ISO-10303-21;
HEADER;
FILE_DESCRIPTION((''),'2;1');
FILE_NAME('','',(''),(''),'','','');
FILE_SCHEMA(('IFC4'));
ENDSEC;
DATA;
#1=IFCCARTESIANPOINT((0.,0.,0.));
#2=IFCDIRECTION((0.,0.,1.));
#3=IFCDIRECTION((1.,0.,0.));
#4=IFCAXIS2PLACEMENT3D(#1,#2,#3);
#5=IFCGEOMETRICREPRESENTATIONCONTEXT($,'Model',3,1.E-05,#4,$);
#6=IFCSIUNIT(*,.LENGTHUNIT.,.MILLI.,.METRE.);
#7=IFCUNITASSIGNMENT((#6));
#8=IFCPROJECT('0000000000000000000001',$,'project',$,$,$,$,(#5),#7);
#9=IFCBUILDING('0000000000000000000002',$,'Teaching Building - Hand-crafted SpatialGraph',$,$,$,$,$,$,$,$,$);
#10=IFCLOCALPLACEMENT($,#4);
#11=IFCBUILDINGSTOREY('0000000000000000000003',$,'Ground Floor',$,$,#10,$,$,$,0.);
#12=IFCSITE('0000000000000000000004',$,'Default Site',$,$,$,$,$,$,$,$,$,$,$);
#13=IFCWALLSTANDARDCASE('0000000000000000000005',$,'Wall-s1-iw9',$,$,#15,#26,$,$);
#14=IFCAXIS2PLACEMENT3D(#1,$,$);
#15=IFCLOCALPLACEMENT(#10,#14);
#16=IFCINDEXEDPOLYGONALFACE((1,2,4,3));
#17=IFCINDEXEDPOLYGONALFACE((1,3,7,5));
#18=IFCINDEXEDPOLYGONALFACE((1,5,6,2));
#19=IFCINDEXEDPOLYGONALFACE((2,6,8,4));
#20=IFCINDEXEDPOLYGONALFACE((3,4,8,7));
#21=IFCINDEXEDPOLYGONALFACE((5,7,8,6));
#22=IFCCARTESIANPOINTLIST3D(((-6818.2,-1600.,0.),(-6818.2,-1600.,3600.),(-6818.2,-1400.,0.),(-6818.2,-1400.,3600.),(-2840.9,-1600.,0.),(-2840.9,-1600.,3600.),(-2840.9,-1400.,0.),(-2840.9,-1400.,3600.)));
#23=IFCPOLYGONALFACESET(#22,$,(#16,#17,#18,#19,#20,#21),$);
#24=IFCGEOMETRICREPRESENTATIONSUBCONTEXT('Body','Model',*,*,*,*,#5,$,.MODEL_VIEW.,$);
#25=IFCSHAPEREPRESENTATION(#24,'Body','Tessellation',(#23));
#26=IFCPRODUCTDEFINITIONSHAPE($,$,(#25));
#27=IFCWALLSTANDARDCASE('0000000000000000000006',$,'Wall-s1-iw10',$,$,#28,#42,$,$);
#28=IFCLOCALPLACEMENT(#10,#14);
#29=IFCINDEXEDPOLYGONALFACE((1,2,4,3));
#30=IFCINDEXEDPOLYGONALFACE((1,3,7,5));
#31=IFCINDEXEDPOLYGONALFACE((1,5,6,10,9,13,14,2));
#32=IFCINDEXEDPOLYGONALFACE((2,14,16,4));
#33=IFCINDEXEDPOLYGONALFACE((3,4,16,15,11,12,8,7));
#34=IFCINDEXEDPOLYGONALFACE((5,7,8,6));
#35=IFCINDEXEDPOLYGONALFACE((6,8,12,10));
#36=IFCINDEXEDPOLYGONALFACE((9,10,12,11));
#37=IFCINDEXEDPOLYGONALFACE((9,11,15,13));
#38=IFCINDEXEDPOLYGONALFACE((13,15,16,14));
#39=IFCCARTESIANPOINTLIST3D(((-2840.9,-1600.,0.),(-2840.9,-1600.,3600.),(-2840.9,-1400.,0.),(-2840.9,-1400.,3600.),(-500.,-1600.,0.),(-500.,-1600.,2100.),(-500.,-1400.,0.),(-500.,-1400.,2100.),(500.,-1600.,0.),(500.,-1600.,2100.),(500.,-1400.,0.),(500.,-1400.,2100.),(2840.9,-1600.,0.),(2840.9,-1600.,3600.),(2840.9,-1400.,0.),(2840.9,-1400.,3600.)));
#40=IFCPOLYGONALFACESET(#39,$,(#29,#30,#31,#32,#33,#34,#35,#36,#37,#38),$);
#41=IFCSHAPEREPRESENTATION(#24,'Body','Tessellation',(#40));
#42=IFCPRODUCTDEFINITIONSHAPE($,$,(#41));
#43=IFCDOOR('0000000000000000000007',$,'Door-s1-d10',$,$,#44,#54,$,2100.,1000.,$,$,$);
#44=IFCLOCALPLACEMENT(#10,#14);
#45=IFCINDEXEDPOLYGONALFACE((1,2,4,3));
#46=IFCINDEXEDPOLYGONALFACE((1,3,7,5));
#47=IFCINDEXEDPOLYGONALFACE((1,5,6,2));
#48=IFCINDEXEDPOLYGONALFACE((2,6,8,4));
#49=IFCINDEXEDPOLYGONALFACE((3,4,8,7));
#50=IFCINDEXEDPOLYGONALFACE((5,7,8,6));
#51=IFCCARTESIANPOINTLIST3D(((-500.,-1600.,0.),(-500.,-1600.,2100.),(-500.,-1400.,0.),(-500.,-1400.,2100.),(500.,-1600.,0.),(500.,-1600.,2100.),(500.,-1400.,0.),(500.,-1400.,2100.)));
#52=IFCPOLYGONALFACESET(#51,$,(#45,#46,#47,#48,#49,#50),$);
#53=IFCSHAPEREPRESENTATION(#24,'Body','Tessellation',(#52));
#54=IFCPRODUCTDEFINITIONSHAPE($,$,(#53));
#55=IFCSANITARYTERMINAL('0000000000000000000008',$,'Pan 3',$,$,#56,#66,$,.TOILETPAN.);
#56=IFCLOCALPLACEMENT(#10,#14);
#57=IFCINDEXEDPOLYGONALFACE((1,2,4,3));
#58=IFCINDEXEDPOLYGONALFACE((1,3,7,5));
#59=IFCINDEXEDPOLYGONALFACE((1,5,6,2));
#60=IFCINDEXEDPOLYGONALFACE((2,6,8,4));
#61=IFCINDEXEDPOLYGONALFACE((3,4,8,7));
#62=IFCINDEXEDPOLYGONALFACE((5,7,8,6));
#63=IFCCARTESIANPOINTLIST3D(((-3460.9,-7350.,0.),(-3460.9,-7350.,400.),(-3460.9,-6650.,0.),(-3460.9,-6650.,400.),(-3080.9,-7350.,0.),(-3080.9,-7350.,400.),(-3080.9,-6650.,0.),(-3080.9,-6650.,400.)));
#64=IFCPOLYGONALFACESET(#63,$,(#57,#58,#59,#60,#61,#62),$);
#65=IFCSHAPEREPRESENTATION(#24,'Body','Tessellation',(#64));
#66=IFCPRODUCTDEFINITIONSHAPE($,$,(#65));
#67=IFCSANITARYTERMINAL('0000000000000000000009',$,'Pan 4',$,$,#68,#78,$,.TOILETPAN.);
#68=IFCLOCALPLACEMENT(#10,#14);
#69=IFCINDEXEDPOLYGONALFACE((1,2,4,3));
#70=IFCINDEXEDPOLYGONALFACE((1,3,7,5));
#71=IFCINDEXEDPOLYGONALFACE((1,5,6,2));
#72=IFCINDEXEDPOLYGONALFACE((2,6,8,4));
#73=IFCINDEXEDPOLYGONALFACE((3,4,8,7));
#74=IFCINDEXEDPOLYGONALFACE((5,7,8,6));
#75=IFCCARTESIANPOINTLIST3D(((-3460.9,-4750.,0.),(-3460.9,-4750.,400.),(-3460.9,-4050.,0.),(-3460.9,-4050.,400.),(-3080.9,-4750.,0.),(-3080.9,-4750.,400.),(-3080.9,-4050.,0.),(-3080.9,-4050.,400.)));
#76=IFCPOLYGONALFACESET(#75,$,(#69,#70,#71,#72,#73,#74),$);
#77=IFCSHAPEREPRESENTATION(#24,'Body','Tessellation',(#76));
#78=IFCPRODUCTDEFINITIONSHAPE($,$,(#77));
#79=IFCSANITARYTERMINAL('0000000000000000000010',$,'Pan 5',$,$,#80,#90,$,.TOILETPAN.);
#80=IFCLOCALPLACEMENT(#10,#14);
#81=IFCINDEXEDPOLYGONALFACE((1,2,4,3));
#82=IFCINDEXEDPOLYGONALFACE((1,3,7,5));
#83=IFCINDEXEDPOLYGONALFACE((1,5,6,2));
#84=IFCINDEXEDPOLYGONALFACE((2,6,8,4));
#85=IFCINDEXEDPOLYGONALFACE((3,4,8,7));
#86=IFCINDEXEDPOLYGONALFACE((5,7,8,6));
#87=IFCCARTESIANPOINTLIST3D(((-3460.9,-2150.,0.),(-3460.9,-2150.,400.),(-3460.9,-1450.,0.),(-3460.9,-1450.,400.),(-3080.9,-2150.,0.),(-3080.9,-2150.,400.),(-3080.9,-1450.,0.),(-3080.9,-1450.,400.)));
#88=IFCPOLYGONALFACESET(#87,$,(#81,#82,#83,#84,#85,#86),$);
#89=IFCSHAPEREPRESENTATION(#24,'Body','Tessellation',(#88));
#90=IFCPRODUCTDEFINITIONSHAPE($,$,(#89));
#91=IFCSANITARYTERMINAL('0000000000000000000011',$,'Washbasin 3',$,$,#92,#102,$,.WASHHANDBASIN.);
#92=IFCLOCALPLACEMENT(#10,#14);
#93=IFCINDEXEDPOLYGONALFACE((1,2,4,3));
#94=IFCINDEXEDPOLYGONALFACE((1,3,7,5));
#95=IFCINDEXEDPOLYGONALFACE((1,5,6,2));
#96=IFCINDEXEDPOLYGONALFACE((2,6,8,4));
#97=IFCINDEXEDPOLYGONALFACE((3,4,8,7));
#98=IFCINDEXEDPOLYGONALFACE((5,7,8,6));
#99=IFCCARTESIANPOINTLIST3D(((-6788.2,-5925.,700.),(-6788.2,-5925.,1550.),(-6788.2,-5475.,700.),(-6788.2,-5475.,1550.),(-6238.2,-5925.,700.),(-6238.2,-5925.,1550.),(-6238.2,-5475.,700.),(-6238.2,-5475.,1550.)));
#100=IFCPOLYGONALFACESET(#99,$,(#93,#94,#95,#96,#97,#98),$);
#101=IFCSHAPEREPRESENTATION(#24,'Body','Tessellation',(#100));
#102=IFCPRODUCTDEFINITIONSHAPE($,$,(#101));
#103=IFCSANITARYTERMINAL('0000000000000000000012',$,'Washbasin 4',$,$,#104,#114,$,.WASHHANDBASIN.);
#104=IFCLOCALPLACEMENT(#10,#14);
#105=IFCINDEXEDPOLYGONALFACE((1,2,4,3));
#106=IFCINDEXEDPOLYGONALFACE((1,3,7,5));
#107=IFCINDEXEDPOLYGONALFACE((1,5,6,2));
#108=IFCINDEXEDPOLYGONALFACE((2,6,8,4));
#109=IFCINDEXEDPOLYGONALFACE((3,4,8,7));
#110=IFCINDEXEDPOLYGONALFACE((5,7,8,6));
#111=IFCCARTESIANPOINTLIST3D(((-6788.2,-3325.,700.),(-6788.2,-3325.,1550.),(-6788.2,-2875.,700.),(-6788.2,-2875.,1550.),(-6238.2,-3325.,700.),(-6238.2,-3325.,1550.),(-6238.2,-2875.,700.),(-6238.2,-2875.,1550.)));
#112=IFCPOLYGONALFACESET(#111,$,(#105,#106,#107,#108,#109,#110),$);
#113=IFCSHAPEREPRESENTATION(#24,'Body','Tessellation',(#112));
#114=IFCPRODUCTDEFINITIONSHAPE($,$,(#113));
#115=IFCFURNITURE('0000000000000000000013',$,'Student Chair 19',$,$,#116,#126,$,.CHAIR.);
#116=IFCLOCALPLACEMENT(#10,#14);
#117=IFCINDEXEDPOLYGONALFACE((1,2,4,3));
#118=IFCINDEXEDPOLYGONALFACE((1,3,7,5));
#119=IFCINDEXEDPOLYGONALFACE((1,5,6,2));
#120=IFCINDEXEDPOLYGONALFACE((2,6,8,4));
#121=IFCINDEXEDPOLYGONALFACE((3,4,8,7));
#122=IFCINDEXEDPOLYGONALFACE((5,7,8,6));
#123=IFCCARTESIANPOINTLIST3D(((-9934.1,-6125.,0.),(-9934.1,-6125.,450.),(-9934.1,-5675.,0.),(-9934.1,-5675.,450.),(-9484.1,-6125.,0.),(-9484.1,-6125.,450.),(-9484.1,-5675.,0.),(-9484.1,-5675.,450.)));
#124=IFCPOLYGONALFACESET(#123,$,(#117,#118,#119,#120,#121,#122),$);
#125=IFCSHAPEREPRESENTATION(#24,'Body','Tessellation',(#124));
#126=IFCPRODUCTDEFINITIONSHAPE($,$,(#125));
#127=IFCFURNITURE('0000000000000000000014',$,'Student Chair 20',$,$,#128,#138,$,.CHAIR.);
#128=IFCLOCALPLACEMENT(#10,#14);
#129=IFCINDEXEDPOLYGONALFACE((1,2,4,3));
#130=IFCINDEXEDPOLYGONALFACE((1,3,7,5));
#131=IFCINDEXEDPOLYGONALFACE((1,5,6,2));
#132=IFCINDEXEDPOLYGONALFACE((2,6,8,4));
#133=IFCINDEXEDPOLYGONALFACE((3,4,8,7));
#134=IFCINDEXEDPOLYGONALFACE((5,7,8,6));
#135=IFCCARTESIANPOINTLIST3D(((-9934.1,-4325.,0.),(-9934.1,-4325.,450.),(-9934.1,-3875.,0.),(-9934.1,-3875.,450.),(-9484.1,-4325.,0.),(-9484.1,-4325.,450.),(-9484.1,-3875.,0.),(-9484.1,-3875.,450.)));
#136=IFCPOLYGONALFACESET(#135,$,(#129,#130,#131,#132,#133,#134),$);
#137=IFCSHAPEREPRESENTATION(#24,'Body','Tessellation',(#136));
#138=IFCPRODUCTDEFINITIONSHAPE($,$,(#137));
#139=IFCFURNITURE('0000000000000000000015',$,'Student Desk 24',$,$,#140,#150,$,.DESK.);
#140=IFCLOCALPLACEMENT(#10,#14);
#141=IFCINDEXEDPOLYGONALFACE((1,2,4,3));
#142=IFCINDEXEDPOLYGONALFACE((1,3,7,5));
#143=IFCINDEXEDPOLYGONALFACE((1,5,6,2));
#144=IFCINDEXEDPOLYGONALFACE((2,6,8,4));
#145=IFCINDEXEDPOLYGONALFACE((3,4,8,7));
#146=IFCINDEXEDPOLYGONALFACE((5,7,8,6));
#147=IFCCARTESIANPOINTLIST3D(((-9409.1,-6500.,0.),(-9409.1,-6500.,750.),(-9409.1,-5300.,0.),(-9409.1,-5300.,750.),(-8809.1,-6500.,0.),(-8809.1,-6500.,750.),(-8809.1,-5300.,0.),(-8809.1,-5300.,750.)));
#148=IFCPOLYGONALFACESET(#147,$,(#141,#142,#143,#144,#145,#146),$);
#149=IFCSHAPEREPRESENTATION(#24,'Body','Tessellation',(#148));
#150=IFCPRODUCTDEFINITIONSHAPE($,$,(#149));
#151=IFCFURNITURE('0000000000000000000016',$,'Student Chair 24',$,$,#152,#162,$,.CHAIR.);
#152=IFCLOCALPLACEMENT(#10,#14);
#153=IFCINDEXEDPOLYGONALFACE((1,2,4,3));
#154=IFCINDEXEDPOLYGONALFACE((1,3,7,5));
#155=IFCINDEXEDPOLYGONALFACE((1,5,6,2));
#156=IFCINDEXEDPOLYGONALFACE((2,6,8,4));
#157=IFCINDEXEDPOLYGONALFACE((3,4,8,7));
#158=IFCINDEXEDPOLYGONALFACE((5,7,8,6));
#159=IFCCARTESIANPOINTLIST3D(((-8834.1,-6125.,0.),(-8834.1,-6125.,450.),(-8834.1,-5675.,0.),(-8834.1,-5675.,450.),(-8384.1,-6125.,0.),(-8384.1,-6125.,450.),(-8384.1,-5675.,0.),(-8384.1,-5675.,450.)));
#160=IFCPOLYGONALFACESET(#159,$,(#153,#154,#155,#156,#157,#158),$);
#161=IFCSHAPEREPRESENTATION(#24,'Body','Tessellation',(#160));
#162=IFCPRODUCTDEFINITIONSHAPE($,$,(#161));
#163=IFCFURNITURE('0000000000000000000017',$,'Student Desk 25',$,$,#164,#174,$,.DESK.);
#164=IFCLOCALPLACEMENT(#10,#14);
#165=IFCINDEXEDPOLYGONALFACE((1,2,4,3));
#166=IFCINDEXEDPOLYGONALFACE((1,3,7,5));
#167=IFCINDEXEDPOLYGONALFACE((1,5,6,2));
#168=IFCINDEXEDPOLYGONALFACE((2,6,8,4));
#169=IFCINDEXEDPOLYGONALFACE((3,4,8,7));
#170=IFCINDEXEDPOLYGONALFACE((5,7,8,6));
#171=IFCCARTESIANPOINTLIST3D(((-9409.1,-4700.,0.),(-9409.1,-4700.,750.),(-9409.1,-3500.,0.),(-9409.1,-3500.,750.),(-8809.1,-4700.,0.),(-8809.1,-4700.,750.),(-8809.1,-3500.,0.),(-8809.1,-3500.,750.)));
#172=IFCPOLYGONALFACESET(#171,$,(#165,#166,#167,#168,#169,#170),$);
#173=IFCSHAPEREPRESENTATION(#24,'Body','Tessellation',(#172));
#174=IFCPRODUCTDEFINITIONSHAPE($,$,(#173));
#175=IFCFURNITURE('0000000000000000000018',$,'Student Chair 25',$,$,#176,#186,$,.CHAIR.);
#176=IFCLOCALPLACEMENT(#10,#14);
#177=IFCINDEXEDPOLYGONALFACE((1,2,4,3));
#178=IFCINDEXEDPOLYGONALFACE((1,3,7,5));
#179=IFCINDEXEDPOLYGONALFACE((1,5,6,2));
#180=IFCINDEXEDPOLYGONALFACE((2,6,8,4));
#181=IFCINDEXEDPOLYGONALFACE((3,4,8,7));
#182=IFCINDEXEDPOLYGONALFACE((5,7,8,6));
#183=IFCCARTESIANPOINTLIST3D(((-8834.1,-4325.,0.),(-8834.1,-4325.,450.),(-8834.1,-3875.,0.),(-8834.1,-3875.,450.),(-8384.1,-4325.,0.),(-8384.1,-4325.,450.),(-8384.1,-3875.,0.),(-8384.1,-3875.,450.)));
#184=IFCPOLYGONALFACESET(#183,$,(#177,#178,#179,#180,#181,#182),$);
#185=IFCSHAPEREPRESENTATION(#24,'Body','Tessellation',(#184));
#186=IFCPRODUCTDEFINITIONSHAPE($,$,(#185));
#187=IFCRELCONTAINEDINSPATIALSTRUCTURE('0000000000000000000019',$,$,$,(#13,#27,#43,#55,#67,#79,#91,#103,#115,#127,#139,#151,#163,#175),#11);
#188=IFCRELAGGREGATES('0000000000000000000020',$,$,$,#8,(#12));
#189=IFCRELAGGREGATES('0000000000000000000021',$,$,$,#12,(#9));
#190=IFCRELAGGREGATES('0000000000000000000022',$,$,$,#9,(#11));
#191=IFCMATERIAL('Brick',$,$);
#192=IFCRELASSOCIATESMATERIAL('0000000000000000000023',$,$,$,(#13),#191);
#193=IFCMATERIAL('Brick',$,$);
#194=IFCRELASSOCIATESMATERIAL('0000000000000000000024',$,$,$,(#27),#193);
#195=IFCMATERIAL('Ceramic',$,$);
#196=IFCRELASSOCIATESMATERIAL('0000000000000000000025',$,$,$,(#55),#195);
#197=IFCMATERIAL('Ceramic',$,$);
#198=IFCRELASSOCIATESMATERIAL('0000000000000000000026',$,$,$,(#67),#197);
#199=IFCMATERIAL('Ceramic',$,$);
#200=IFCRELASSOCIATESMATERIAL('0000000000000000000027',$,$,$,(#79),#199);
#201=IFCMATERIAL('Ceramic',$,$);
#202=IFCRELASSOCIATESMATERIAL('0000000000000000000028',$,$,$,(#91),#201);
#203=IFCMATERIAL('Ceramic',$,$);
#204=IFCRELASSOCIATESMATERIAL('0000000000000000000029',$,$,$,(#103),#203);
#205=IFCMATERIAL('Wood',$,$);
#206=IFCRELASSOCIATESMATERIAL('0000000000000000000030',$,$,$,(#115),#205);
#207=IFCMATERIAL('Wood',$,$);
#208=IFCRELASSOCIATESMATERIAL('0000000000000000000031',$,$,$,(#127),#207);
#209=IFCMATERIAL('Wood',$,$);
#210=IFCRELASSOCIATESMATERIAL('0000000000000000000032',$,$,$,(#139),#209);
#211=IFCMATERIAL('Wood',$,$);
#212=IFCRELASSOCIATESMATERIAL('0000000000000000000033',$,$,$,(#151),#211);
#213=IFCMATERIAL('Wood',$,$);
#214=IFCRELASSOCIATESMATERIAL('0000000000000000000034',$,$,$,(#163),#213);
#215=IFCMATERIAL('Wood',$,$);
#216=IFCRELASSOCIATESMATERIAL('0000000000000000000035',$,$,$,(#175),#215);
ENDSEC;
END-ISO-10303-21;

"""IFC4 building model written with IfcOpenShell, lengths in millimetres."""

from ifc_helpers import new_model, si_unit, frame, frame_2d, origin_with_axes, origin_2d, place, context, subcontext, project, spatial, rectangle, extrude, material, element, fill, save


model = new_model("IFC4")

# Units and contexts
model_context = context("Model", 3, precision=1e-05, world=origin_with_axes())
body_context = subcontext(model_context, "Body", "Model", "MODEL_VIEW")
ifc_project = project(units=[si_unit("LENGTHUNIT", "METRE", prefix="MILLI")], contexts=[model_context])

# Site, building, storey
site = spatial("IfcSite", under=ifc_project, Name="Default Site")
building = spatial("IfcBuilding", under=site, Name="Teaching Building - Hand-crafted SpatialGraph")
storey_placement = place(None, origin_with_axes())
storey = spatial("IfcBuildingStorey", under=building, at=storey_placement, Name="Ground Floor", Elevation=0.0)

# Wall
ifc_material_1 = material(Name="Brick")
wall_1_placement = place(storey_placement, frame((-6818.2, -1500.0, 0.0), z_axis=(0.0, 0.0, 1.0), x_axis=(1.0, 0.0, 0.0)))
element("IfcWallStandardCase", 1, at=wall_1_placement, inside=storey, material=ifc_material_1, Name="Wall-s1-iw9", context=body_context, shape_type="SweptSolid", body=[
    extrude(rectangle(XDim=3977.3, YDim=200.0, at=frame_2d((1988.6, 0.0))), origin_with_axes(), (0.0, 0.0, 1.0), 3600.0),
])

# Wall, opening, door
ifc_material_2 = material(Name="Brick")
wall_2_placement = place(storey_placement, frame((-2840.9, -1500.0, 0.0), z_axis=(0.0, 0.0, 1.0), x_axis=(1.0, 0.0, 0.0)))
wall_2 = element("IfcWallStandardCase", 2, at=wall_2_placement, inside=storey, material=ifc_material_2, Name="Wall-s1-iw10", context=body_context, shape_type="SweptSolid", body=[
    extrude(rectangle(XDim=5681.8, YDim=200.0, at=frame_2d((2840.9, 0.0))), origin_with_axes(), (0.0, 0.0, 1.0), 3600.0),
])
opening_placement = place(wall_2_placement, frame((2340.9, 0.0, 0.0), z_axis=(0.0, 0.0, 1.0), x_axis=(1.0, 0.0, 0.0)))
opening = element("IfcOpeningElement", 3, at=opening_placement, cuts=wall_2, context=body_context, shape_type="SweptSolid", body=[
    extrude(rectangle(XDim=1000.0, YDim=400.0, at=frame_2d((500.0, 0.0))), origin_with_axes(), (0.0, 0.0, 1.0), 2100.0),
])
door_placement = place(storey_placement, frame((-500.0, -1500.0, 0.0), z_axis=(0.0, 0.0, 1.0), x_axis=(1.0, 0.0, 0.0)))
door = element("IfcDoor", 4, at=door_placement, inside=storey, Name="Door-s1-d10", OverallHeight=2100.0, OverallWidth=1000.0, context=body_context, shape_type="SweptSolid", body=[
    extrude(rectangle(XDim=1000.0, YDim=200.0, at=frame_2d((500.0, 0.0))), origin_with_axes(), (0.0, 0.0, 1.0), 2100.0),
])
fill(opening, door)

# Sanitary terminals
ifc_material_3 = material(Name="Ceramic")
sanitary_terminal_1_placement = place(storey_placement, frame((-3270.9, -7000.0, 0.0), z_axis=(0.0, 0.0, 1.0), x_axis=(0.0, 1.0, 0.0)))
element("IfcSanitaryTerminal", 5, at=sanitary_terminal_1_placement, inside=storey, material=ifc_material_3, Name="Pan 3", PredefinedType="TOILETPAN", context=body_context, shape_type="SweptSolid", body=[
    extrude(rectangle(XDim=700.0, YDim=380.0, at=origin_2d()), origin_with_axes(), (0.0, 0.0, 1.0), 400.0),
])
ifc_material_4 = material(Name="Ceramic")
sanitary_terminal_2_placement = place(storey_placement, frame((-3270.9, -4400.0, 0.0), z_axis=(0.0, 0.0, 1.0), x_axis=(0.0, 1.0, 0.0)))
element("IfcSanitaryTerminal", 6, at=sanitary_terminal_2_placement, inside=storey, material=ifc_material_4, Name="Pan 4", PredefinedType="TOILETPAN", context=body_context, shape_type="SweptSolid", body=[
    extrude(rectangle(XDim=700.0, YDim=380.0, at=origin_2d()), origin_with_axes(), (0.0, 0.0, 1.0), 400.0),
])
ifc_material_5 = material(Name="Ceramic")
sanitary_terminal_3_placement = place(storey_placement, frame((-3270.9, -1800.0, 0.0), z_axis=(0.0, 0.0, 1.0), x_axis=(0.0, 1.0, 0.0)))
element("IfcSanitaryTerminal", 7, at=sanitary_terminal_3_placement, inside=storey, material=ifc_material_5, Name="Pan 5", PredefinedType="TOILETPAN", context=body_context, shape_type="SweptSolid", body=[
    extrude(rectangle(XDim=700.0, YDim=380.0, at=origin_2d()), origin_with_axes(), (0.0, 0.0, 1.0), 400.0),
])
ifc_material_6 = material(Name="Ceramic")
sanitary_terminal_4_placement = place(storey_placement, frame((-6513.2, -5700.0, 700.0), z_axis=(0.0, 0.0, 1.0), x_axis=(0.0, 1.0, 0.0)))
element("IfcSanitaryTerminal", 8, at=sanitary_terminal_4_placement, inside=storey, material=ifc_material_6, Name="Washbasin 3", PredefinedType="WASHHANDBASIN", context=body_context, shape_type="SweptSolid", body=[
    extrude(rectangle(XDim=450.0, YDim=550.0, at=origin_2d()), origin_with_axes(), (0.0, 0.0, 1.0), 850.0),
])
ifc_material_7 = material(Name="Ceramic")
sanitary_terminal_5_placement = place(storey_placement, frame((-6513.2, -3100.0, 700.0), z_axis=(0.0, 0.0, 1.0), x_axis=(0.0, 1.0, 0.0)))
element("IfcSanitaryTerminal", 9, at=sanitary_terminal_5_placement, inside=storey, material=ifc_material_7, Name="Washbasin 4", PredefinedType="WASHHANDBASIN", context=body_context, shape_type="SweptSolid", body=[
    extrude(rectangle(XDim=450.0, YDim=550.0, at=origin_2d()), origin_with_axes(), (0.0, 0.0, 1.0), 850.0),
])

# Furniture
ifc_material_8 = material(Name="Wood")
furniture_1_placement = place(storey_placement, frame((-9709.1, -5900.0, 0.0), z_axis=(0.0, 0.0, 1.0), x_axis=(1.0, 0.0, 0.0)))
element("IfcFurniture", 10, at=furniture_1_placement, inside=storey, material=ifc_material_8, Name="Student Chair 19", PredefinedType="CHAIR", context=body_context, shape_type="SweptSolid", body=[
    extrude(rectangle(XDim=450.0, YDim=450.0, at=origin_2d()), origin_with_axes(), (0.0, 0.0, 1.0), 450.0),
])
ifc_material_9 = material(Name="Wood")
furniture_2_placement = place(storey_placement, frame((-9709.1, -4100.0, 0.0), z_axis=(0.0, 0.0, 1.0), x_axis=(1.0, 0.0, 0.0)))
element("IfcFurniture", 11, at=furniture_2_placement, inside=storey, material=ifc_material_9, Name="Student Chair 20", PredefinedType="CHAIR", context=body_context, shape_type="SweptSolid", body=[
    extrude(rectangle(XDim=450.0, YDim=450.0, at=origin_2d()), origin_with_axes(), (0.0, 0.0, 1.0), 450.0),
])
ifc_material_10 = material(Name="Wood")
furniture_3_placement = place(storey_placement, frame((-9109.1, -5900.0, 0.0), z_axis=(0.0, 0.0, 1.0), x_axis=(0.0, 1.0, 0.0)))
element("IfcFurniture", 12, at=furniture_3_placement, inside=storey, material=ifc_material_10, Name="Student Desk 24", PredefinedType="DESK", context=body_context, shape_type="SweptSolid", body=[
    extrude(rectangle(XDim=1200.0, YDim=600.0, at=origin_2d()), origin_with_axes(), (0.0, 0.0, 1.0), 750.0),
])
ifc_material_11 = material(Name="Wood")
furniture_4_placement = place(storey_placement, frame((-8609.1, -5900.0, 0.0), z_axis=(0.0, 0.0, 1.0), x_axis=(1.0, 0.0, 0.0)))
element("IfcFurniture", 13, at=furniture_4_placement, inside=storey, material=ifc_material_11, Name="Student Chair 24", PredefinedType="CHAIR", context=body_context, shape_type="SweptSolid", body=[
    extrude(rectangle(XDim=450.0, YDim=450.0, at=origin_2d()), origin_with_axes(), (0.0, 0.0, 1.0), 450.0),
])
ifc_material_12 = material(Name="Wood")
furniture_5_placement = place(storey_placement, frame((-9109.1, -4100.0, 0.0), z_axis=(0.0, 0.0, 1.0), x_axis=(0.0, 1.0, 0.0)))
element("IfcFurniture", 14, at=furniture_5_placement, inside=storey, material=ifc_material_12, Name="Student Desk 25", PredefinedType="DESK", context=body_context, shape_type="SweptSolid", body=[
    extrude(rectangle(XDim=1200.0, YDim=600.0, at=origin_2d()), origin_with_axes(), (0.0, 0.0, 1.0), 750.0),
])
ifc_material_13 = material(Name="Wood")
furniture_6_placement = place(storey_placement, frame((-8609.1, -4100.0, 0.0), z_axis=(0.0, 0.0, 1.0), x_axis=(1.0, 0.0, 0.0)))
element("IfcFurniture", 15, at=furniture_6_placement, inside=storey, material=ifc_material_13, Name="Student Chair 25", PredefinedType="CHAIR", context=body_context, shape_type="SweptSolid", body=[
    extrude(rectangle(XDim=450.0, YDim=450.0, at=origin_2d()), origin_with_axes(), (0.0, 0.0, 1.0), 450.0),
])

save(model, "model.ifc")
